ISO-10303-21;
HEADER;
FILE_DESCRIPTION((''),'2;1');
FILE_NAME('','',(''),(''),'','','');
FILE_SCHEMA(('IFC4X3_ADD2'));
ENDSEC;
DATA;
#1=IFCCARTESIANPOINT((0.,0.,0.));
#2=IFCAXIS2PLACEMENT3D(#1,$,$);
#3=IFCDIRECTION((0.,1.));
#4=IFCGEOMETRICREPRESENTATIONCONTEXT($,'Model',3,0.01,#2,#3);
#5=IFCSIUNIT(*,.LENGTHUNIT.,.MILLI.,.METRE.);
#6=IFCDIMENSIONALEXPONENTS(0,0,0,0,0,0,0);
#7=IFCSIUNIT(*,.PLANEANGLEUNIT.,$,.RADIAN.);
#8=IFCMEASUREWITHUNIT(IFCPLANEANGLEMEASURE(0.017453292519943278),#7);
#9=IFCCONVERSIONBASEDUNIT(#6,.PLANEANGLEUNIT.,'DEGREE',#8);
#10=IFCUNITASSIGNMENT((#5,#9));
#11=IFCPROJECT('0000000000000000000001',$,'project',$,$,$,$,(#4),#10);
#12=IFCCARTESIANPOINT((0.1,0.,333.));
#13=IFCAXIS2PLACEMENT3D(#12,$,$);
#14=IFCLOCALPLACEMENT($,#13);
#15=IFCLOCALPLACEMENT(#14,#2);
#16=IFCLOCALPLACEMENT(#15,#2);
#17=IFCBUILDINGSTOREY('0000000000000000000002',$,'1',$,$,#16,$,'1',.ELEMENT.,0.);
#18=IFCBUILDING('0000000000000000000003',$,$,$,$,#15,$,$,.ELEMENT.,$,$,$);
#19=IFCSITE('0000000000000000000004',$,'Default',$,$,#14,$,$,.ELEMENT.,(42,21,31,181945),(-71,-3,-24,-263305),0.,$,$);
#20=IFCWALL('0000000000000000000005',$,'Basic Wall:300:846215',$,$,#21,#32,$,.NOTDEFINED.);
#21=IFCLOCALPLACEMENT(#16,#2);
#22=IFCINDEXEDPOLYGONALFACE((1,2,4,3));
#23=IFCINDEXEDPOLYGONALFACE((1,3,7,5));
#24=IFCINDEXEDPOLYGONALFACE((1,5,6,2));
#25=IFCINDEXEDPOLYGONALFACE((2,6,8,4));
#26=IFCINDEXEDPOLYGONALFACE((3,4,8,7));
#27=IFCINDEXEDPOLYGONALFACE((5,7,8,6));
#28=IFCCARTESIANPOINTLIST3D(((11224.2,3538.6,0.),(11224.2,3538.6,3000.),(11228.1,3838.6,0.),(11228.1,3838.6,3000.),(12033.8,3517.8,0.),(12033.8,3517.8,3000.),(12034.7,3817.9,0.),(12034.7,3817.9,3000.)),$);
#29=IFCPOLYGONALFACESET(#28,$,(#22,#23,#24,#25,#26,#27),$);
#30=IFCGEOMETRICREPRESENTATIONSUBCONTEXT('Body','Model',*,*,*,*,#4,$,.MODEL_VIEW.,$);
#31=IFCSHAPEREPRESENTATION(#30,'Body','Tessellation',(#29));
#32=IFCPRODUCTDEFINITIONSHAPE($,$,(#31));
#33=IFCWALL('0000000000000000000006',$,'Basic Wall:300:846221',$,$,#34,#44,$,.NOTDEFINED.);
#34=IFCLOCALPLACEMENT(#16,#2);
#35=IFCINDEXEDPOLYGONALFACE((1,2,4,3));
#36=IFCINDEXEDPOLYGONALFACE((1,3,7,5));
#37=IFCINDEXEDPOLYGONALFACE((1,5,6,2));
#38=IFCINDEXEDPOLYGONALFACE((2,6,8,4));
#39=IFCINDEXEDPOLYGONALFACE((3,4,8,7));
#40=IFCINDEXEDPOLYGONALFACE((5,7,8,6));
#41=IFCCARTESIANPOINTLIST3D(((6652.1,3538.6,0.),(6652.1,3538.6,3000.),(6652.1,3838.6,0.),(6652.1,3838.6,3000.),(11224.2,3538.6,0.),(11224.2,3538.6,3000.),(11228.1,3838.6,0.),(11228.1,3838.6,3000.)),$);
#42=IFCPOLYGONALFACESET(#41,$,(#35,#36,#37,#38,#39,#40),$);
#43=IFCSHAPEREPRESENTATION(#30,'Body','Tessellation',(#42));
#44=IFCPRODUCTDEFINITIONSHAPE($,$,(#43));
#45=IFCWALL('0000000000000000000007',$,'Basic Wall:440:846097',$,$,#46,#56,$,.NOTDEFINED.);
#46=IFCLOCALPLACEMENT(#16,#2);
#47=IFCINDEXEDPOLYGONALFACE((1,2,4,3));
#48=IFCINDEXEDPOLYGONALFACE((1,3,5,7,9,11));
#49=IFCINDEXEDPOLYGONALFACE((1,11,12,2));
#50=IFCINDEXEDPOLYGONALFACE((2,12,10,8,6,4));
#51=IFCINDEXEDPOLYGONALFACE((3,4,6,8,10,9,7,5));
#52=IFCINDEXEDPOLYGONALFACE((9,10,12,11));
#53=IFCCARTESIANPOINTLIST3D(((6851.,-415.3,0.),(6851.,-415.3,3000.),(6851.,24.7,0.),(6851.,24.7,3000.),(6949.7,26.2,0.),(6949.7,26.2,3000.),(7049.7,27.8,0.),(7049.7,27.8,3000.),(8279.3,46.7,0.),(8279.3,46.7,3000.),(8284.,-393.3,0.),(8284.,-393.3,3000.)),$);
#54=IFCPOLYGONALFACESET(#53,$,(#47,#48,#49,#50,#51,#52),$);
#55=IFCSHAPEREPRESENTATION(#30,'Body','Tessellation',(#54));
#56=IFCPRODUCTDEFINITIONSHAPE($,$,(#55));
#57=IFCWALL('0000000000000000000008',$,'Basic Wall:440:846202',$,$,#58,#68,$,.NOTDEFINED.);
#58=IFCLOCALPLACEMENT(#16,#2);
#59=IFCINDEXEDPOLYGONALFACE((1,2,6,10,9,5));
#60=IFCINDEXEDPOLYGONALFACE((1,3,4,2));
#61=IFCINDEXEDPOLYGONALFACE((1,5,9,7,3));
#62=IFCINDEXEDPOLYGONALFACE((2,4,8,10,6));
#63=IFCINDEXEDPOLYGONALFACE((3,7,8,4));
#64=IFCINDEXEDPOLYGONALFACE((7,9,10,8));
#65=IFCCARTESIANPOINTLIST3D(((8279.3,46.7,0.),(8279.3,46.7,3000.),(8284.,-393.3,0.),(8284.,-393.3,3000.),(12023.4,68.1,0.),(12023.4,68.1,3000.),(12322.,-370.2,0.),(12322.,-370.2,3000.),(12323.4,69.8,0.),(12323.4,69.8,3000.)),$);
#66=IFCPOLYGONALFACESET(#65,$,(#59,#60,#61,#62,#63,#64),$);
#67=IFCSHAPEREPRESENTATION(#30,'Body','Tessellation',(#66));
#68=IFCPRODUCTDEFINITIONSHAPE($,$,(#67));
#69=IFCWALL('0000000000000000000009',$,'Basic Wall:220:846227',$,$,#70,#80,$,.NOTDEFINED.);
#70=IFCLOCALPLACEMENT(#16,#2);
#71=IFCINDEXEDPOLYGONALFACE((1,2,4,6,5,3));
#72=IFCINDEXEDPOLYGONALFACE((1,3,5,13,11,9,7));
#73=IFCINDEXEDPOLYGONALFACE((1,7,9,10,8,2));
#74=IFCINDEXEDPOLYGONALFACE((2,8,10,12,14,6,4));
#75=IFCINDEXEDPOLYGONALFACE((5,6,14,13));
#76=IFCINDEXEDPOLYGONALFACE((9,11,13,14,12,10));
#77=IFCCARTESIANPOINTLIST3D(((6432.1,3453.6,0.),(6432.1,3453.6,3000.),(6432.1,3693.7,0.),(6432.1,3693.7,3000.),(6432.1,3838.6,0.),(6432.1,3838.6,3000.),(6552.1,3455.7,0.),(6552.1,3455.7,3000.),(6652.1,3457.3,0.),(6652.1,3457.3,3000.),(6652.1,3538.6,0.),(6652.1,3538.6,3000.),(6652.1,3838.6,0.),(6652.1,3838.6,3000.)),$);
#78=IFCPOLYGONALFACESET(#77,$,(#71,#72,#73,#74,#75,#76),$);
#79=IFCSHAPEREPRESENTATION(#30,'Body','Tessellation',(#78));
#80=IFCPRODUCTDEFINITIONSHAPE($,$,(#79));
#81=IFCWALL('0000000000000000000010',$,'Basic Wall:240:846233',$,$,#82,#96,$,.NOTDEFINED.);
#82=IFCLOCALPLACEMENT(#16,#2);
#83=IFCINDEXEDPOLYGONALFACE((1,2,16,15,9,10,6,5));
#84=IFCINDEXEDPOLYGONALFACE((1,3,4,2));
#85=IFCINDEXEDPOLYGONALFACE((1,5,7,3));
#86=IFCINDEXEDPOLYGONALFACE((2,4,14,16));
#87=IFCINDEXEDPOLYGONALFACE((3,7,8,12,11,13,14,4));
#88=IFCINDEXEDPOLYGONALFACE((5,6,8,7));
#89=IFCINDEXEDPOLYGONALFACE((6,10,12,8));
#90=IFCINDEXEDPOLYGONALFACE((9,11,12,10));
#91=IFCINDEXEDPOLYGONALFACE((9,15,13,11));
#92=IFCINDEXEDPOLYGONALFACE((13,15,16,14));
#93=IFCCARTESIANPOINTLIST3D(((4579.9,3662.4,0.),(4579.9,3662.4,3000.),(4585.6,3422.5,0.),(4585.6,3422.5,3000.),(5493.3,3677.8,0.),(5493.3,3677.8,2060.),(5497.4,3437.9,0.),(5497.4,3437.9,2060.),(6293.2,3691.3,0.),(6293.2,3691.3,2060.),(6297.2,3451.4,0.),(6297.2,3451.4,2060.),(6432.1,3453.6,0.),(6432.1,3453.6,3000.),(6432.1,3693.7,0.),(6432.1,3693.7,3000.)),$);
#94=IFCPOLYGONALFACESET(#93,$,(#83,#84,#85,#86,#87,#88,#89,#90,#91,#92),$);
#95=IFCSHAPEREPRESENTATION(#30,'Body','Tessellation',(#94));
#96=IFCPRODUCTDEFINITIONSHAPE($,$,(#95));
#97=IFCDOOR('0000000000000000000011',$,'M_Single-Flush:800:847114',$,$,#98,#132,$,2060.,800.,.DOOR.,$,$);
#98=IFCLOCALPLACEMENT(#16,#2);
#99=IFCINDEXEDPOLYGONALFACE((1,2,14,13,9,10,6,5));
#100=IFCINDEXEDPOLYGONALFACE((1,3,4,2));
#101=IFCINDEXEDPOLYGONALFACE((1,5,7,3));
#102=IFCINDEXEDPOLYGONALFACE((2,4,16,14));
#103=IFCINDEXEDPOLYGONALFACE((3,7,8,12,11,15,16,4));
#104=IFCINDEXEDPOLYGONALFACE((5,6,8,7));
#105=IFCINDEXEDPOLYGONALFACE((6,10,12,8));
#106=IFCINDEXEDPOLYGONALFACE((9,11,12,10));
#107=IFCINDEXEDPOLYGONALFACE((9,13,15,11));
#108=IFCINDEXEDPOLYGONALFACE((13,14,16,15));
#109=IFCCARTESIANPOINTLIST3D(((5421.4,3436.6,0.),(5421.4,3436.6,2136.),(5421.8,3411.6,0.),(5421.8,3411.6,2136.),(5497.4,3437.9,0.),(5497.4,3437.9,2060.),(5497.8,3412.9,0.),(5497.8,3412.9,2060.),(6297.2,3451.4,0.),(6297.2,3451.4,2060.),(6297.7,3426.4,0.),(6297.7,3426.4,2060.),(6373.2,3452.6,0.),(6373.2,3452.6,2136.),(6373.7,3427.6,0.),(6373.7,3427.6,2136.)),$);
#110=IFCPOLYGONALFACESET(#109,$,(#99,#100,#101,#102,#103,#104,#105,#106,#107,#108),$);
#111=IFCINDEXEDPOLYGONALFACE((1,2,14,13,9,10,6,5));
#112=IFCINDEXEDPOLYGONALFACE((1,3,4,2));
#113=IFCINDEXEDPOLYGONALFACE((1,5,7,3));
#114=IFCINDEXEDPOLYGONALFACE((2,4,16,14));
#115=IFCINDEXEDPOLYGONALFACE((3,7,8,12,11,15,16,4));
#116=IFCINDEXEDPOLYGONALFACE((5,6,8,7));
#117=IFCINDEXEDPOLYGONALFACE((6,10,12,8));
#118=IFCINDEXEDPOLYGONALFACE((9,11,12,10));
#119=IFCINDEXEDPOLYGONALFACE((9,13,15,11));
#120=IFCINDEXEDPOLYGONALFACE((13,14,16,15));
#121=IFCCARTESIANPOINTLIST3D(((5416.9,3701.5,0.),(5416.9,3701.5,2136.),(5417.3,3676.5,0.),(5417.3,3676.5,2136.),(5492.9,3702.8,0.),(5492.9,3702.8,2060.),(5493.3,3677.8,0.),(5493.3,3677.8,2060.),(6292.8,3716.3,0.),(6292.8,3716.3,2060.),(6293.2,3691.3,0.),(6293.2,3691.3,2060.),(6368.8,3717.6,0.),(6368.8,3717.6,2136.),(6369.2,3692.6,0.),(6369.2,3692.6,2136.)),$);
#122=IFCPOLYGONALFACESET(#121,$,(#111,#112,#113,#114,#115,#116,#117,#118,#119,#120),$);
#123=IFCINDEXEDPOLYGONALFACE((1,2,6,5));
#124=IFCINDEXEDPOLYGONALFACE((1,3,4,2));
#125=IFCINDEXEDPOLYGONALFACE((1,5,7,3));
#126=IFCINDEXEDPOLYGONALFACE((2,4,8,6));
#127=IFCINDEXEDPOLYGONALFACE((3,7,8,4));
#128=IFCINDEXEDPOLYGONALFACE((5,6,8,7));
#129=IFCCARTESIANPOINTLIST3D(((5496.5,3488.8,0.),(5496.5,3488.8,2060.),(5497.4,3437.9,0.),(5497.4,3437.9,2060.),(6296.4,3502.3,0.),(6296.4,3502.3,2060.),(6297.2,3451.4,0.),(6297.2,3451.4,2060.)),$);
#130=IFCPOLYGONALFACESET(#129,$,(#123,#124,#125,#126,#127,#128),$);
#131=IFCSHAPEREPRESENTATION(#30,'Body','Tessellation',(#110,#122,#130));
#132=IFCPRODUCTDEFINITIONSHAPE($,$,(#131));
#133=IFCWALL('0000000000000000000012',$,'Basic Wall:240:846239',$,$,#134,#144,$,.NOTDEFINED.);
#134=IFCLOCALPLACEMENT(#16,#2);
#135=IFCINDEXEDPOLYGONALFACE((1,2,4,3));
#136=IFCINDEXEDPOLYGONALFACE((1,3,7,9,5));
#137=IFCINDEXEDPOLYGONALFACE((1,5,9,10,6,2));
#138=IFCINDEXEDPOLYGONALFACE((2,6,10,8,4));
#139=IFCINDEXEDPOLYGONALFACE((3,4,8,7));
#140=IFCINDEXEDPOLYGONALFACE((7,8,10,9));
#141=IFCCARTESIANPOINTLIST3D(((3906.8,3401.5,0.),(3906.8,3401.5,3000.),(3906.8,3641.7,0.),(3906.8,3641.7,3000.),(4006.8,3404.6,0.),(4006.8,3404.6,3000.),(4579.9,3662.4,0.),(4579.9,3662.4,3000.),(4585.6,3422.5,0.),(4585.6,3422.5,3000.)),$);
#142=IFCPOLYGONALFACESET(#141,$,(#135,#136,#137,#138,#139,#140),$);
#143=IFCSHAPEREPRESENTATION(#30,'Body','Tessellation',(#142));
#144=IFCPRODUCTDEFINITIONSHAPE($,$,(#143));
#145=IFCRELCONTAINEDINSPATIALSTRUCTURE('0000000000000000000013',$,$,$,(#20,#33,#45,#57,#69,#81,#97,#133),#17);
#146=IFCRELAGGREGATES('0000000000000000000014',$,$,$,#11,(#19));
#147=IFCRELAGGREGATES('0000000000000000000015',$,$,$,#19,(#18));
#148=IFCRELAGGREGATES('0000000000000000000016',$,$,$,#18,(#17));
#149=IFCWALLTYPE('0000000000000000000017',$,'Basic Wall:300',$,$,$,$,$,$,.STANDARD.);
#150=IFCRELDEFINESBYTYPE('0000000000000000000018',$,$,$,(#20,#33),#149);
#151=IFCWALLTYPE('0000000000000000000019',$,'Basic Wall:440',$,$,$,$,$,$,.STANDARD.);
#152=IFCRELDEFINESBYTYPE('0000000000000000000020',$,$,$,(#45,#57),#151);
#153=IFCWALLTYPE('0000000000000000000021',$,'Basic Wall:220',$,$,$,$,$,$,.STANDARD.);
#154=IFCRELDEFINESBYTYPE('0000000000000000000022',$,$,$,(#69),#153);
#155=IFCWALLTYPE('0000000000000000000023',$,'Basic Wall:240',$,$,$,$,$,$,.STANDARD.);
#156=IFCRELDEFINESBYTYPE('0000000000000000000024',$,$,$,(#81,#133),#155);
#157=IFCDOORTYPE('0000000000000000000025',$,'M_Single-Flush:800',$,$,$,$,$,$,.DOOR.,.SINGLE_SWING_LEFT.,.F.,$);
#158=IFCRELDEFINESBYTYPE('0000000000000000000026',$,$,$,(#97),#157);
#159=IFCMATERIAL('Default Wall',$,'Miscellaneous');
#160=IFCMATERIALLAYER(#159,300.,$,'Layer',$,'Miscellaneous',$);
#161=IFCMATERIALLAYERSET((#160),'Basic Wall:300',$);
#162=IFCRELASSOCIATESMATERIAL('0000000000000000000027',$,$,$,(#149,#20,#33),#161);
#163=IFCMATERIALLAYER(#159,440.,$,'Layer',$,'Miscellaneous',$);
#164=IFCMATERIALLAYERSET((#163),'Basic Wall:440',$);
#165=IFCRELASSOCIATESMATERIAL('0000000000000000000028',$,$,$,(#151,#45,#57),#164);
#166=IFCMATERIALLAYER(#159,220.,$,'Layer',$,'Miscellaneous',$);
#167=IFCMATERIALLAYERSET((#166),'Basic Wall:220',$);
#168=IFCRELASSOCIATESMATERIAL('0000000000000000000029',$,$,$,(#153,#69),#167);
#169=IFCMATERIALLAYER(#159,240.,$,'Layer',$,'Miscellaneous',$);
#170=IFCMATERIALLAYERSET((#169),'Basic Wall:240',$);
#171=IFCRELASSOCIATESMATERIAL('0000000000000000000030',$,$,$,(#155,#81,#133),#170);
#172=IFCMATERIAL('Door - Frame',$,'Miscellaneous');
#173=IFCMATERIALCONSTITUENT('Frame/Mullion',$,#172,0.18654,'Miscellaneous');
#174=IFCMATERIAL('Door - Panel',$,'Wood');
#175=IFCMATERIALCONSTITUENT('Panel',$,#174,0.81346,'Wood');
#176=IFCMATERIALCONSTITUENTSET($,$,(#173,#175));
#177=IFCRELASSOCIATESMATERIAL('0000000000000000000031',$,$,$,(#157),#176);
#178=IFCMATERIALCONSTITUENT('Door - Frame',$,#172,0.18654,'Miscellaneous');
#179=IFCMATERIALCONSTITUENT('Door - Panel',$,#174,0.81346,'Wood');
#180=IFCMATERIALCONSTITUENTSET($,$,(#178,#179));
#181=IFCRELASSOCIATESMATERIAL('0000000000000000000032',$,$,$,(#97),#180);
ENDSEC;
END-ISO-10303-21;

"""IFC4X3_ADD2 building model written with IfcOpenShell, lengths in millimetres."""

from ifc_helpers import new_model, entity, si_unit, converted_unit, direction, frame, frame_2d, origin, place, context, subcontext, project, spatial, polyline, rectangle, outline, extrude, source, transform, mapped, material, layer, layer_set, constituent, constituent_set, type_object, type_shapes, element, fill, save


model = new_model("IFC4X3_ADD2")

# Units and contexts
model_context = context("Model", 3, precision=0.01, world=origin(), true_north=direction((0.0, 1.0)))
body_context = subcontext(model_context, "Body", "Model", "MODEL_VIEW")
ifc_project = project(units=[si_unit("LENGTHUNIT", "METRE", prefix="MILLI"), converted_unit("PLANEANGLEUNIT", "DEGREE", entity("IfcPlaneAngleMeasure", 0.017453292519943278), si_unit("PLANEANGLEUNIT", "RADIAN"), dimensions=[0, 0, 0, 0, 0, 0, 0])], contexts=[model_context])

# Site, building, storey
site_placement = place(None, frame((0.1, 0.0, 333.0)))
site = spatial("IfcSite", under=ifc_project, at=site_placement, Name="Default", CompositionType="ELEMENT", RefLatitude=(42, 21, 31, 181945), RefLongitude=(-71, -3, -24, -263305), RefElevation=0.0)
building_placement = place(site_placement, origin())
building = spatial("IfcBuilding", under=site, at=building_placement, CompositionType="ELEMENT")
storey_placement = place(building_placement, origin())
storey = spatial("IfcBuildingStorey", under=building, at=storey_placement, Name="1", LongName="1", CompositionType="ELEMENT", Elevation=0.0)

# Shared definitions
ifc_material_1 = material(Name="Default Wall", Category="Miscellaneous")
ifc_layer_1 = layer(ifc_material_1, 300.0, Name="Layer", Category="Miscellaneous")
ifc_layer_set_1 = layer_set([ifc_layer_1], Name="Basic Wall:300")
wall_type_1 = type_object("IfcWallType", Name="Basic Wall:300", PredefinedType="STANDARD", material=ifc_layer_set_1)

# Walls
wall_1_placement = place(storey_placement, frame((11224.2, 3688.7, 0.0), z_axis=(0.0, 0.0, 1.0), x_axis=(0.99967, -0.025697, 0.0)))
element("IfcWall", 1, at=wall_1_placement, inside=storey, type_object=wall_type_1, material=ifc_layer_set_1, Name="Basic Wall:300:846215", PredefinedType="NOTDEFINED", context=body_context, shape_type="SweptSolid", body=[
    extrude(outline(polyline([(813.6, -150.0), (806.8, 150.0), (0.0, 150.0), (3.9, -150.0), (813.6, -150.0)])), origin(), (0.0, 0.0, 1.0), 3000.0),
])
wall_2_placement = place(storey_placement, frame((6652.1, 3688.6, 0.0)))
element("IfcWall", 2, at=wall_2_placement, inside=storey, type_object=wall_type_1, material=ifc_layer_set_1, Name="Basic Wall:300:846221", PredefinedType="NOTDEFINED", context=body_context, shape_type="SweptSolid", body=[
    extrude(outline(polyline([(4572.1, -150.0), (4576.0, 150.0), (0.0, 150.0), (0.0, -150.0), (4572.1, -150.0)])), origin(), (0.0, 0.0, 1.0), 3000.0),
])
ifc_layer_2 = layer(ifc_material_1, 440.0, Name="Layer", Category="Miscellaneous")
ifc_layer_set_2 = layer_set([ifc_layer_2], Name="Basic Wall:440")
wall_type_2 = type_object("IfcWallType", Name="Basic Wall:440", PredefinedType="STANDARD", material=ifc_layer_set_2)
wall_3_placement = place(storey_placement, frame((8282.7, -173.2, 0.0), z_axis=(0.0, 0.0, 1.0), x_axis=(-0.999881, -0.015407, 0.0)))
element("IfcWall", 3, at=wall_3_placement, inside=storey, type_object=wall_type_2, material=ifc_layer_set_2, Name="Basic Wall:440:846097", PredefinedType="NOTDEFINED", context=body_context, shape_type="SweptSolid", body=[
    extrude(outline(polyline([(1428.5, -220.0), (1435.3, 220.0), (2.1, 220.0), (0.0, -220.0), (1229.8, -220.0), (1329.8, -220.0), (1428.5, -220.0)])), origin(), (0.0, 0.0, 1.0), 3000.0),
])
wall_4_placement = place(storey_placement, frame((12324.6, -150.2, 0.0), z_axis=(0.0, 0.0, 1.0), x_axis=(-0.999984, -0.005702, 0.0)))
element("IfcWall", 4, at=wall_4_placement, inside=storey, type_object=wall_type_2, material=ifc_layer_set_2, Name="Basic Wall:440:846202", PredefinedType="NOTDEFINED", context=body_context, shape_type="SweptSolid", body=[
    extrude(outline(polyline([(4044.1, -220.0), (4041.9, 220.0), (3.8, 220.0), (0.0, -220.0), (300.0, -220.0), (4044.1, -220.0)])), origin(), (0.0, 0.0, 1.0), 3000.0),
])
ifc_layer_3 = layer(ifc_material_1, 220.0, Name="Layer", Category="Miscellaneous")
ifc_layer_set_3 = layer_set([ifc_layer_3], Name="Basic Wall:220")
wall_type_3 = type_object("IfcWallType", Name="Basic Wall:220", PredefinedType="STANDARD", material=ifc_layer_set_3)
wall_5_placement = place(storey_placement, frame((6542.1, 3453.6, 0.0), z_axis=(0.0, 0.0, 1.0), x_axis=(0.0, 1.0, 0.0)))
element("IfcWall", 5, at=wall_5_placement, inside=storey, type_object=wall_type_3, material=ifc_layer_set_3, Name="Basic Wall:220:846227", PredefinedType="NOTDEFINED", context=body_context, shape_type="SweptSolid", body=[
    extrude(outline(polyline([(385.0, -110.0), (385.0, 110.0), (240.0, 110.0), (0.0, 110.0), (2.0, -10.0), (3.7, -110.0), (85.0, -110.0), (385.0, -110.0)])), origin(), (0.0, 0.0, 1.0), 3000.0),
])

# Wall, opening, door
ifc_layer_4 = layer(ifc_material_1, 240.0, Name="Layer", Category="Miscellaneous")
ifc_layer_set_4 = layer_set([ifc_layer_4], Name="Basic Wall:240")
wall_type_4 = type_object("IfcWallType", Name="Basic Wall:240", PredefinedType="STANDARD", material=ifc_layer_set_4)
wall_6_placement = place(storey_placement, frame((4581.9, 3542.4, 0.0), z_axis=(0.0, 0.0, 1.0), x_axis=(0.999858, 0.016875, 0.0)))
wall_6 = element("IfcWall", 6, at=wall_6_placement, inside=storey, type_object=wall_type_4, material=ifc_layer_set_4, Name="Basic Wall:240:846233", PredefinedType="NOTDEFINED", context=body_context, shape_type="SweptSolid", body=[
    extrude(outline(polyline([(1.7, -120.0), (214.1, -120.0), (314.2, -120.0), (1848.4, -120.0), (1852.5, 120.0), (0.0, 120.0), (1.7, -120.0)])), origin(), (0.0, 0.0, 1.0), 3000.0),
])
opening_1_placement = place(wall_6_placement, frame((1713.5, 120.0, 0.0)))
opening_1 = element("IfcOpeningElement", 7, at=opening_1_placement, cuts=wall_6, PredefinedType="OPENING", context=body_context, shape_type="SweptSolid", body=[
    extrude(rectangle(XDim=800.0, YDim=2060.0, at=frame_2d((1030.0, 400.0), x_axis=(0.0, -1.0))), frame((0.0, 0.0, 0.0), z_axis=(0.0, -1.0, 0.0), x_axis=(0.0, 0.0, 1.0)), (0.0, 0.0, 1.0), 240.0),
])
ifc_material_2 = material(Name="Door - Frame", Category="Miscellaneous")
ifc_constituent_1 = constituent(ifc_material_2, Name="Door - Frame", Category="Miscellaneous", fraction=0.18654)
ifc_material_3 = material(Name="Door - Panel", Category="Wood")
ifc_constituent_2 = constituent(ifc_material_3, Name="Door - Panel", Category="Wood", fraction=0.81346)
ifc_constituent_set_1 = constituent_set(constituents=[ifc_constituent_1, ifc_constituent_2])
ifc_constituent_3 = constituent(ifc_material_2, Name="Frame/Mullion", Category="Miscellaneous", fraction=0.18654)
ifc_constituent_4 = constituent(ifc_material_3, Name="Panel", Category="Wood", fraction=0.81346)
ifc_constituent_set_2 = constituent_set(constituents=[ifc_constituent_3, ifc_constituent_4])
door_type_1 = type_object("IfcDoorType", Name="M_Single-Flush:800", OperationType="SINGLE_SWING_LEFT", ParameterTakesPrecedence=False, PredefinedType="DOOR", material=ifc_constituent_set_2)
shared_shape_1 = source(origin(), body_context, "Body", "SweptSolid", [
    extrude(outline(polyline([(-476.0, -1087.0), (476.0, -1087.0), (476.0, 1049.0), (400.0, 1049.0), (400.0, -1011.0), (-400.0, -1011.0), (-400.0, 1049.0), (-476.0, 1049.0), (-476.0, -1087.0)])), frame((400.0, 265.0, 1049.0), z_axis=(0.0, -1.0, 0.0), x_axis=(-1.0, 0.0, 0.0)), (0.0, 0.0, 1.0), 25.0),
    extrude(outline(polyline([(-1087.0, -476.0), (1049.0, -476.0), (1049.0, -400.0), (-1011.0, -400.0), (-1011.0, 400.0), (1049.0, 400.0), (1049.0, 476.0), (-1087.0, 476.0), (-1087.0, -476.0)])), frame((400.0, 0.0, 1049.0), z_axis=(0.0, -1.0, 0.0), x_axis=(0.0, 0.0, -1.0)), (0.0, 0.0, 1.0), 25.0),
    extrude(rectangle(XDim=800.0, YDim=51.0, at=frame_2d((0.0, 0.0), x_axis=(1.0, 0.0))), frame((400.0, 214.5, 0.0)), (0.0, 0.0, 1.0), 2060.0),
])
type_shapes(door_type_1, [shared_shape_1])
door_1_placement = place(opening_1_placement, frame((0.0, 0.0, 0.0), z_axis=(0.0, 0.0, 1.0), x_axis=(-1.0, 0.0, 0.0)))
door_1 = element("IfcDoor", 8, at=door_1_placement, inside=storey, type_object=door_type_1, material=ifc_constituent_set_1, Name="M_Single-Flush:800:847114", OverallHeight=2060.0, OverallWidth=800.0, PredefinedType="DOOR", context=body_context, shape_type="MappedRepresentation", body=[
    mapped(shared_shape_1, transform((0.0, 0.0, 0.0), scale=1.0)),
])
fill(opening_1, door_1)

# Wall
wall_7_placement = place(storey_placement, frame((3903.1, 3521.5, 0.0), z_axis=(0.0, 0.0, 1.0), x_axis=(0.999526, 0.030802, 0.0)))
element("IfcWall", 9, at=wall_7_placement, inside=storey, type_object=wall_type_4, material=ifc_layer_set_4, Name="Basic Wall:240:846239", PredefinedType="NOTDEFINED", context=body_context, shape_type="SweptSolid", body=[
    extrude(outline(polyline([(679.2, -120.0), (680.8, 120.0), (7.4, 120.0), (0.0, -120.0), (100.0, -120.0), (679.2, -120.0)])), origin(), (0.0, 0.0, 1.0), 3000.0),
])

save(model, "model.ifc")
